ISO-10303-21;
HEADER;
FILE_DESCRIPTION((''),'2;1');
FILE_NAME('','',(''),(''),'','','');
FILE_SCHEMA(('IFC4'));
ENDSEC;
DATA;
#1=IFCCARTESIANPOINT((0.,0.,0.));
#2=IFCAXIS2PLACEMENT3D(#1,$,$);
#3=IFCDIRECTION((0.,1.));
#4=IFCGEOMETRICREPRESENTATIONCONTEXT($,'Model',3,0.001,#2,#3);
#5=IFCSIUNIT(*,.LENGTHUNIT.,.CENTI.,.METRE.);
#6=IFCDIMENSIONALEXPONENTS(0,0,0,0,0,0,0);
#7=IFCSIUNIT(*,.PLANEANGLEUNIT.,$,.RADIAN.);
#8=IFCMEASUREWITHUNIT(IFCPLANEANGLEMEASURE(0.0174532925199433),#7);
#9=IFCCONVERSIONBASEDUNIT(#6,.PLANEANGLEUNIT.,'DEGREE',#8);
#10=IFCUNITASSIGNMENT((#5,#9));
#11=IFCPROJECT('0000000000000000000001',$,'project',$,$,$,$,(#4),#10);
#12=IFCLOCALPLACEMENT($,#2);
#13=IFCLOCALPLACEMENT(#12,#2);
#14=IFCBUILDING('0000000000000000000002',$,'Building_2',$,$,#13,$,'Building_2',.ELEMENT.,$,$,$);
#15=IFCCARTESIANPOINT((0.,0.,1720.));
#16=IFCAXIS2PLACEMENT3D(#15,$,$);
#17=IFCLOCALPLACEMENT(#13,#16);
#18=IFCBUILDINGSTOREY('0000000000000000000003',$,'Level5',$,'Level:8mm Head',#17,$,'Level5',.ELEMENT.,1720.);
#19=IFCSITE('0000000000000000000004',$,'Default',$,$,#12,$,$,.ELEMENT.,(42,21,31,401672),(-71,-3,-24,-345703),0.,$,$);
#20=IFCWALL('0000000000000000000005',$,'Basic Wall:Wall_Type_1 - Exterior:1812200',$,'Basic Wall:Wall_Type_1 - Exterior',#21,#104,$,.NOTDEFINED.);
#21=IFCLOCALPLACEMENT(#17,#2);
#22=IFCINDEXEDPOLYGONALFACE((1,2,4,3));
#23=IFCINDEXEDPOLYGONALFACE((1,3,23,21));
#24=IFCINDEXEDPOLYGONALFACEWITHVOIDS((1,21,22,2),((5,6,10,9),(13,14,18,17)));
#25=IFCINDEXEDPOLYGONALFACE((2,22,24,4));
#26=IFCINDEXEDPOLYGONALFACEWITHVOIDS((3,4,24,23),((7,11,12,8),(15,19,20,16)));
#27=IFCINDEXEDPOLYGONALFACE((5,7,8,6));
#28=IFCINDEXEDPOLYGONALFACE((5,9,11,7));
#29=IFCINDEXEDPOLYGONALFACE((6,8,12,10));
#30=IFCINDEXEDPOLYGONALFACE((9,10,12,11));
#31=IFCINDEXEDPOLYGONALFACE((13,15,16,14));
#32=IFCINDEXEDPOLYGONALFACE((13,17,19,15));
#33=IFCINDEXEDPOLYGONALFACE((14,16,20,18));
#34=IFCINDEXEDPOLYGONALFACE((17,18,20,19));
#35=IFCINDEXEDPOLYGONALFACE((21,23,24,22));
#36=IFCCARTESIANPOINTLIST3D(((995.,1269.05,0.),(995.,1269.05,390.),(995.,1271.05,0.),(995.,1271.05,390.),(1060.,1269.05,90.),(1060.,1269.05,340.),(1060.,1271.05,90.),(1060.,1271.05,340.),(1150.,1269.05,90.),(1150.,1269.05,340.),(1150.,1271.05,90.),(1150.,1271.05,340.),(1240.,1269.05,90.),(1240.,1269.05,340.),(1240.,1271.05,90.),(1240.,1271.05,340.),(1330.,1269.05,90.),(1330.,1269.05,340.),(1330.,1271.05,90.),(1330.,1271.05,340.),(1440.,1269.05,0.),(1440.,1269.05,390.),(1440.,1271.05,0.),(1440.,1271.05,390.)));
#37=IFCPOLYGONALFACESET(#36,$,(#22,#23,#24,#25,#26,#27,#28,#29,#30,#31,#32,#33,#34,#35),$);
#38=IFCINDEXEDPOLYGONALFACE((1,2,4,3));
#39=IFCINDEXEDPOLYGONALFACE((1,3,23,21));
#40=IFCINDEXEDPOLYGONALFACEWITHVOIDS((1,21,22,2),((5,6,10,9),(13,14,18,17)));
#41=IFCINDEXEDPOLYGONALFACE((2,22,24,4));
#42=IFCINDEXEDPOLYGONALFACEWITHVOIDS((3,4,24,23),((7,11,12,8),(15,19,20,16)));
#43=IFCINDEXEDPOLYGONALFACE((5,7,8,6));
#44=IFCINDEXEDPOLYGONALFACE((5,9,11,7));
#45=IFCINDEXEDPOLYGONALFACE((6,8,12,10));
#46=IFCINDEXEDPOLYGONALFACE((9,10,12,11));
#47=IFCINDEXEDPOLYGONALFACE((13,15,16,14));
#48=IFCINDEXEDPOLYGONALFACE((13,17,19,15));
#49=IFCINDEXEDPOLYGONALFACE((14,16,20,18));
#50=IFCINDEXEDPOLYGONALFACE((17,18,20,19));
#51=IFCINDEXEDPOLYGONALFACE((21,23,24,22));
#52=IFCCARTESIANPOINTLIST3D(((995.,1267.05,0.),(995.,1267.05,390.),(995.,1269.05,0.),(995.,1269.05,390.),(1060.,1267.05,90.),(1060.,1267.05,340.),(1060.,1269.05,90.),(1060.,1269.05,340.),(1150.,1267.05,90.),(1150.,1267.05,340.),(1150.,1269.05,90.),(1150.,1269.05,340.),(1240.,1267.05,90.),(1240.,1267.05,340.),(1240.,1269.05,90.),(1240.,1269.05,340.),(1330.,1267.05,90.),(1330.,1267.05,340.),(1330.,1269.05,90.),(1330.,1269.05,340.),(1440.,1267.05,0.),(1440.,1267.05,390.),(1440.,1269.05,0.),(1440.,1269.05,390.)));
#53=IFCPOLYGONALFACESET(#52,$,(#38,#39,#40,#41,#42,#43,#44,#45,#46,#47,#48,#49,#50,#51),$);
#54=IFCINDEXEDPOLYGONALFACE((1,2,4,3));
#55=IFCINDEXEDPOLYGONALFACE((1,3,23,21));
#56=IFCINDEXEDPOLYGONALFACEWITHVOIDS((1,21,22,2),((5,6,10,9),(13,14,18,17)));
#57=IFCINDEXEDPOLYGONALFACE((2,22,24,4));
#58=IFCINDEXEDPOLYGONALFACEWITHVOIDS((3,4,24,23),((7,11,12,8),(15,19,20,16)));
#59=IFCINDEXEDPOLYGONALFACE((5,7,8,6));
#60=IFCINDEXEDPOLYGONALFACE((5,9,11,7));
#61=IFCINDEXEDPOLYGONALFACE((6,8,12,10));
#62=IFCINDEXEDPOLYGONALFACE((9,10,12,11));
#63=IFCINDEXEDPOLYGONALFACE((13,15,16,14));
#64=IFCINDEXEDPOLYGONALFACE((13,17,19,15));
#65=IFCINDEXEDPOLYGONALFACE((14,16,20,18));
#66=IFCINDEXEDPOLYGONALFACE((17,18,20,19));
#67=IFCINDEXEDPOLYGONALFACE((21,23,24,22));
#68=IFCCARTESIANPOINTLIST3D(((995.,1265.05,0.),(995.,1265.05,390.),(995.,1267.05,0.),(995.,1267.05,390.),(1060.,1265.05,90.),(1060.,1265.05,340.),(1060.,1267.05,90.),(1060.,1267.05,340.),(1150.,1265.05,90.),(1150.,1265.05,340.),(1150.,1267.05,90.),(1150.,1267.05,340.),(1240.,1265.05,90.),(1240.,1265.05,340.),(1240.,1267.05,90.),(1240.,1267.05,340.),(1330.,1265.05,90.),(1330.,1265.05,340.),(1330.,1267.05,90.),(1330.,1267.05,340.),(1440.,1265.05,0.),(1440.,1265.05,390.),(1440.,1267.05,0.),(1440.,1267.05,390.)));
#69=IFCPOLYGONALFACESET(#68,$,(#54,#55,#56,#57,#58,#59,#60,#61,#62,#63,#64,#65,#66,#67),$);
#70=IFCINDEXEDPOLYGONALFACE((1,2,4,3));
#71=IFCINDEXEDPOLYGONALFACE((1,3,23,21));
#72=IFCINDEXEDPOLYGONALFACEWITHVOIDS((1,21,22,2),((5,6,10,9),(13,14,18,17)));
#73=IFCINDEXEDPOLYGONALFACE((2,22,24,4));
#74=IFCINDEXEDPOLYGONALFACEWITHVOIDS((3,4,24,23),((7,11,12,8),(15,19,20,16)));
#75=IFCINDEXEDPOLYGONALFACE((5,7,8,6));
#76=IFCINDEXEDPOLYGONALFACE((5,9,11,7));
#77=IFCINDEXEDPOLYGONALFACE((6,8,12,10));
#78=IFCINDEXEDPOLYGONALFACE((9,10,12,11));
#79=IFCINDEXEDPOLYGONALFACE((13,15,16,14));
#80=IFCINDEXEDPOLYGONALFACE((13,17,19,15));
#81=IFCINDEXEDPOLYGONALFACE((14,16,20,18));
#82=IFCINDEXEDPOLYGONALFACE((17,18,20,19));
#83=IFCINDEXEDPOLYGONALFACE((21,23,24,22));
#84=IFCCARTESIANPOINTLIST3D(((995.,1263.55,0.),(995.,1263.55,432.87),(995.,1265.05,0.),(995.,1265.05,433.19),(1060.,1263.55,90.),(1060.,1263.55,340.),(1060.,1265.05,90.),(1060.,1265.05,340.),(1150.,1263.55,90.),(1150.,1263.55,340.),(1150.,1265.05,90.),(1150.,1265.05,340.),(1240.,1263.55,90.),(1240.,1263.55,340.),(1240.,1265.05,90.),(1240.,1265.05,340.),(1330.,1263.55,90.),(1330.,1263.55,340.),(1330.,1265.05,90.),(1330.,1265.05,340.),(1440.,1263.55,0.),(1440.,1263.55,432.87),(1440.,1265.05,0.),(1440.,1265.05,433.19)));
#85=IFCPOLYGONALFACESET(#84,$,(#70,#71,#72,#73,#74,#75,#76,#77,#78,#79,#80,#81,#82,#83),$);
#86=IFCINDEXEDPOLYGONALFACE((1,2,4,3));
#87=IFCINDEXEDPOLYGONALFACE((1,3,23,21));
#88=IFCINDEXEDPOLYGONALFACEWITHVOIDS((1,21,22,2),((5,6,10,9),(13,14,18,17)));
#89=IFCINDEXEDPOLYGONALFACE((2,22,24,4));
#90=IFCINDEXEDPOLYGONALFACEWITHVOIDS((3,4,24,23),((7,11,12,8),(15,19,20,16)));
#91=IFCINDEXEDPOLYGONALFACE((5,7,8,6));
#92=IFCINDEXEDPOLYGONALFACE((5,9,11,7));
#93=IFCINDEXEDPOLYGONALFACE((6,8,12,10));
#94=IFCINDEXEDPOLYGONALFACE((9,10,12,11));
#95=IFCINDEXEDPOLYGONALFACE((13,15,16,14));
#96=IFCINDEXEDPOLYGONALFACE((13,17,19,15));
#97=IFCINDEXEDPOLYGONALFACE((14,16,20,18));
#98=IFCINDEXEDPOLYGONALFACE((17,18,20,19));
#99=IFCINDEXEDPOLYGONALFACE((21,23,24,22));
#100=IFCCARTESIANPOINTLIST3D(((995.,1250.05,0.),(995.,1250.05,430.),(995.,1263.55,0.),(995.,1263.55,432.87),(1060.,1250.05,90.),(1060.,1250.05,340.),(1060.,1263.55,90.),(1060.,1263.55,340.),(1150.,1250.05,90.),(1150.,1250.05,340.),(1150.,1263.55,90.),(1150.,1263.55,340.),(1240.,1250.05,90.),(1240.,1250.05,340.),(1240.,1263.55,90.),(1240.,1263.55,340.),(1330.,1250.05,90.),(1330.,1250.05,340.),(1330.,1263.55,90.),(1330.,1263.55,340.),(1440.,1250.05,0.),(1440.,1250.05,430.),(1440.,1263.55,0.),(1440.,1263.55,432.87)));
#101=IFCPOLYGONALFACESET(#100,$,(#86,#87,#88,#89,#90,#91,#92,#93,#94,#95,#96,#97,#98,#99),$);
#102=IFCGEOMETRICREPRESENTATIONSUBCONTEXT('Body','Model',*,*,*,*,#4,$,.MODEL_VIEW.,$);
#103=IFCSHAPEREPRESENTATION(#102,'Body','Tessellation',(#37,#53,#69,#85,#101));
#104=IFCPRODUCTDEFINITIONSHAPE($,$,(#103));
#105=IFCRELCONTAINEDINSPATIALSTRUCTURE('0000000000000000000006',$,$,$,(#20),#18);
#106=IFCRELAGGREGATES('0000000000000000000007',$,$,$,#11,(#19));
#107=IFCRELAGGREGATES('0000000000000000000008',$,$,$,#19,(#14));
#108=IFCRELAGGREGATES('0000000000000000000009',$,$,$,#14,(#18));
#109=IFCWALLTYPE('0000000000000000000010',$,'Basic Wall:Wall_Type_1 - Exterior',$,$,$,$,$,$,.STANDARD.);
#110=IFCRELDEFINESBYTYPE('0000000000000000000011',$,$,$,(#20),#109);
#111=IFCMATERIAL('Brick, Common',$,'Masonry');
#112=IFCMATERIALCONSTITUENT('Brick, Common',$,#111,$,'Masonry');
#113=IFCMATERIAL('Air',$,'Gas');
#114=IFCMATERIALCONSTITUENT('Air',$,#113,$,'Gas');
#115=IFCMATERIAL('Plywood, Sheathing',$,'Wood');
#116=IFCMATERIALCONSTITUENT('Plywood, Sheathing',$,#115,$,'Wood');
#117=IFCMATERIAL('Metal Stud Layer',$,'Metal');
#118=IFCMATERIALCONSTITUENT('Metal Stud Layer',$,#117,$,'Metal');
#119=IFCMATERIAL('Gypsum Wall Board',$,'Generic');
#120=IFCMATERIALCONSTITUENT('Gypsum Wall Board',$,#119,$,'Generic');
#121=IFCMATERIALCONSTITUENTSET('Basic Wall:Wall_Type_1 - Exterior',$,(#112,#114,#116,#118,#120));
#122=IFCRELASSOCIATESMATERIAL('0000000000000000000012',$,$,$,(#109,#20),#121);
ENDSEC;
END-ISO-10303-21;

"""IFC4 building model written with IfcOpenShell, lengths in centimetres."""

from ifc_helpers import new_model, entity, si_unit, converted_unit, direction, frame, origin, place, context, subcontext, project, spatial, indexed_curve, outline, extrude, material, constituent, constituent_set, type_object, element, save


model = new_model("IFC4")

# Units and contexts
model_context = context("Model", 3, precision=0.001, world=origin(), true_north=direction((0.0, 1.0)))
body_context = subcontext(model_context, "Body", "Model", "MODEL_VIEW")
ifc_project = project(units=[si_unit("LENGTHUNIT", "METRE", prefix="CENTI"), converted_unit("PLANEANGLEUNIT", "DEGREE", entity("IfcPlaneAngleMeasure", 0.0174532925199433), si_unit("PLANEANGLEUNIT", "RADIAN"), dimensions=[0, 0, 0, 0, 0, 0, 0])], contexts=[model_context])

# Site, building, storey
site_placement = place(None, origin())
site = spatial("IfcSite", under=ifc_project, at=site_placement, Name="Default", CompositionType="ELEMENT", RefLatitude=(42, 21, 31, 401672), RefLongitude=(-71, -3, -24, -345703), RefElevation=0.0)
building_placement = place(site_placement, origin())
building = spatial("IfcBuilding", under=site, at=building_placement, Name="Building_2", LongName="Building_2", CompositionType="ELEMENT")
storey_placement = place(building_placement, frame((0.0, 0.0, 1720.0)))
storey = spatial("IfcBuildingStorey", under=building, at=storey_placement, Name="Level5", ObjectType="Level:8mm Head", LongName="Level5", CompositionType="ELEMENT", Elevation=1720.0)

# Shared definitions
ifc_material_1 = material(Name="Brick, Common", Category="Masonry")
ifc_constituent_1 = constituent(ifc_material_1, Name="Brick, Common", Category="Masonry")
ifc_material_2 = material(Name="Air", Category="Gas")
ifc_constituent_2 = constituent(ifc_material_2, Name="Air", Category="Gas")
ifc_material_3 = material(Name="Plywood, Sheathing", Category="Wood")
ifc_constituent_3 = constituent(ifc_material_3, Name="Plywood, Sheathing", Category="Wood")
ifc_material_4 = material(Name="Metal Stud Layer", Category="Metal")
ifc_constituent_4 = constituent(ifc_material_4, Name="Metal Stud Layer", Category="Metal")
ifc_material_5 = material(Name="Gypsum Wall Board", Category="Generic")
ifc_constituent_5 = constituent(ifc_material_5, Name="Gypsum Wall Board", Category="Generic")
ifc_constituent_set_1 = constituent_set(constituents=[ifc_constituent_1, ifc_constituent_2, ifc_constituent_3, ifc_constituent_4, ifc_constituent_5], Name="Basic Wall:Wall_Type_1 - Exterior")
wall_type_1 = type_object("IfcWallType", Name="Basic Wall:Wall_Type_1 - Exterior", PredefinedType="STANDARD", material=ifc_constituent_set_1)

# Wall, openings
wall_1_placement = place(storey_placement, frame((1440.0, 1260.55, 0.0), z_axis=(0.0, 0.0, 1.0), x_axis=(-1.0, 0.0, 0.0)))
wall_1 = element("IfcWall", 1, at=wall_1_placement, inside=storey, type_object=wall_type_1, material=ifc_constituent_set_1, Name="Basic Wall:Wall_Type_1 - Exterior:1812200", ObjectType="Basic Wall:Wall_Type_1 - Exterior", PredefinedType="NOTDEFINED", context=body_context, shape_type="SweptSolid", body=[
    extrude(outline(indexed_curve([(-195.0, -222.5), (195.0, -222.5), (195.0, 222.5), (-195.0, 222.5), (-195.0, -222.5)], self_intersect=False), holes=[indexed_curve([(145.0, -157.5), (-105.0, -157.5), (-105.0, -67.5), (145.0, -67.5), (145.0, -157.5)], self_intersect=False), indexed_curve([(145.0, 22.5), (-105.0, 22.5), (-105.0, 112.5), (145.0, 112.5), (145.0, 22.5)], self_intersect=False)]), frame((222.5, -8.5, 195.0), z_axis=(0.0, -1.0, 0.0), x_axis=(0.0, 0.0, 1.0)), (0.0, 0.0, 1.0), 2.0),
    extrude(outline(indexed_curve([(-195.0, -222.5), (195.0, -222.5), (195.0, 222.5), (-195.0, 222.5), (-195.0, -222.5)], self_intersect=False), holes=[indexed_curve([(145.0, -157.5), (-105.0, -157.5), (-105.0, -67.5), (145.0, -67.5), (145.0, -157.5)], self_intersect=False), indexed_curve([(145.0, 22.5), (-105.0, 22.5), (-105.0, 112.5), (145.0, 112.5), (145.0, 22.5)], self_intersect=False)]), frame((222.5, -6.5, 195.0), z_axis=(0.0, -1.0, 0.0), x_axis=(0.0, 0.0, 1.0)), (0.0, 0.0, 1.0), 2.0),
    extrude(outline(indexed_curve([(-195.0, -222.5), (195.0, -222.5), (195.0, 222.5), (-195.0, 222.5), (-195.0, -222.5)], self_intersect=False), holes=[indexed_curve([(145.0, -157.5), (-105.0, -157.5), (-105.0, -67.5), (145.0, -67.5), (145.0, -157.5)], self_intersect=False), indexed_curve([(145.0, 22.5), (-105.0, 22.5), (-105.0, 112.5), (145.0, 112.5), (145.0, 22.5)], self_intersect=False)]), frame((222.5, -4.5, 195.0), z_axis=(0.0, -1.0, 0.0), x_axis=(0.0, 0.0, 1.0)), (0.0, 0.0, 1.0), 2.0),
    extrude(outline(indexed_curve([(-181.66, -0.9), (251.21, -0.9), (251.21, 0.6), (-138.79, 0.6), (-181.98, 0.6), (-181.66, -0.9)], self_intersect=False)), frame((445.0, -3.9, 251.21), z_axis=(-1.0, 0.0, 0.0), x_axis=(0.0, 0.0, -1.0)), (0.0, 0.0, 1.0), 445.0),
    extrude(outline(indexed_curve([(-6.75, -215.72), (6.75, -215.72), (6.75, 217.15), (-6.75, 214.28), (-6.75, -215.72)], self_intersect=False)), frame((445.0, 3.75, 215.72), z_axis=(-1.0, 0.0, 0.0), x_axis=(0.0, -1.0, 0.0)), (0.0, 0.0, 1.0), 445.0),
])
opening_1_placement = place(storey_placement, frame((1440.0, 1260.55, 0.0), z_axis=(0.0, 0.0, 1.0), x_axis=(-1.0, 0.0, 0.0)))
element("IfcOpeningElement", 2, at=opening_1_placement, cuts=wall_1, PredefinedType="OPENING", context=body_context, shape_type="SweptSolid", body=[
    extrude(outline(indexed_curve([(-45.0, -125.0), (45.0, -125.0), (45.0, 125.0), (-45.0, 125.0), (-45.0, -125.0)], self_intersect=False)), frame((335.0, 10.5, 215.0), z_axis=(0.0, -1.0, 0.0), x_axis=(-1.0, 0.0, 0.0)), (0.0, 0.0, 1.0), 13.5),
])
opening_2_placement = place(storey_placement, frame((1440.0, 1260.55, 0.0), z_axis=(0.0, 0.0, 1.0), x_axis=(-1.0, 0.0, 0.0)))
element("IfcOpeningElement", 3, at=opening_2_placement, cuts=wall_1, PredefinedType="OPENING", context=body_context, shape_type="SweptSolid", body=[
    extrude(outline(indexed_curve([(-45.0, -125.0), (45.0, -125.0), (45.0, 125.0), (-45.0, 125.0), (-45.0, -125.0)], self_intersect=False)), frame((155.0, 10.5, 215.0), z_axis=(0.0, -1.0, 0.0), x_axis=(-1.0, 0.0, 0.0)), (0.0, 0.0, 1.0), 13.5),
])
opening_3_placement = place(storey_placement, frame((1440.0, 1260.55, 0.0), z_axis=(0.0, 0.0, 1.0), x_axis=(-1.0, 0.0, 0.0)))
element("IfcOpeningElement", 4, at=opening_3_placement, cuts=wall_1, PredefinedType="OPENING", context=body_context, shape_type="SweptSolid", body=[
    extrude(outline(indexed_curve([(-45.0, -125.0), (45.0, -125.0), (45.0, 125.0), (-45.0, 125.0), (-45.0, -125.0)], self_intersect=False)), frame((335.0, -4.5, 215.0), z_axis=(0.0, 1.0, 0.0), x_axis=(1.0, 0.0, 0.0)), (0.0, 0.0, 1.0), 1.5),
])
opening_4_placement = place(storey_placement, frame((1440.0, 1260.55, 0.0), z_axis=(0.0, 0.0, 1.0), x_axis=(-1.0, 0.0, 0.0)))
element("IfcOpeningElement", 5, at=opening_4_placement, cuts=wall_1, PredefinedType="OPENING", context=body_context, shape_type="SweptSolid", body=[
    extrude(outline(indexed_curve([(-45.0, -125.0), (45.0, -125.0), (45.0, 125.0), (-45.0, 125.0), (-45.0, -125.0)], self_intersect=False)), frame((155.0, -4.5, 215.0), z_axis=(0.0, 1.0, 0.0), x_axis=(1.0, 0.0, 0.0)), (0.0, 0.0, 1.0), 1.5),
])
opening_5_placement = place(wall_1_placement, frame((380.0, 10.5, 90.0)))
element("IfcOpeningElement", 6, at=opening_5_placement, cuts=wall_1, PredefinedType="OPENING", context=body_context, shape_type="SweptSolid", body=[
    extrude(outline(indexed_curve([(250.0, 90.0), (0.0, 90.0), (0.0, 0.0), (250.0, 0.0), (250.0, 90.0)], self_intersect=False)), frame((0.0, 0.0, 0.0), z_axis=(0.0, -1.0, 0.0), x_axis=(0.0, 0.0, 1.0)), (0.0, 0.0, 1.0), 21.0),
])
opening_6_placement = place(wall_1_placement, frame((1440.0, 1260.55, 0.0), z_axis=(0.0, 0.0, 1.0), x_axis=(-1.0, 0.0, 0.0)))
element("IfcOpeningElement", 7, at=opening_6_placement, cuts=wall_1, PredefinedType="OPENING", context=body_context, shape_type="SweptSolid", body=[
    extrude(outline(indexed_curve([(-45.0, -125.0), (45.0, -125.0), (45.0, 125.0), (-45.0, 125.0), (-45.0, -125.0)], self_intersect=False)), frame((1105.0, 1402.45, 215.0), z_axis=(0.0, -1.0, 0.0), x_axis=(-1.0, 0.0, 0.0)), (0.0, 0.0, 1.0), 304.8),
])
opening_7_placement = place(wall_1_placement, frame((200.0, 10.5, 90.0)))
element("IfcOpeningElement", 8, at=opening_7_placement, cuts=wall_1, PredefinedType="OPENING", context=body_context, shape_type="SweptSolid", body=[
    extrude(outline(indexed_curve([(250.0, 90.0), (0.0, 90.0), (0.0, 0.0), (250.0, 0.0), (250.0, 90.0)], self_intersect=False)), frame((0.0, 0.0, 0.0), z_axis=(0.0, -1.0, 0.0), x_axis=(0.0, 0.0, 1.0)), (0.0, 0.0, 1.0), 21.0),
])
opening_8_placement = place(wall_1_placement, frame((1440.0, 1260.55, 0.0), z_axis=(0.0, 0.0, 1.0), x_axis=(-1.0, 0.0, 0.0)))
element("IfcOpeningElement", 9, at=opening_8_placement, cuts=wall_1, PredefinedType="OPENING", context=body_context, shape_type="SweptSolid", body=[
    extrude(outline(indexed_curve([(-45.0, -125.0), (45.0, -125.0), (45.0, 125.0), (-45.0, 125.0), (-45.0, -125.0)], self_intersect=False)), frame((1285.0, 1402.45, 215.0), z_axis=(0.0, -1.0, 0.0), x_axis=(-1.0, 0.0, 0.0)), (0.0, 0.0, 1.0), 304.8),
])

save(model, "model.ifc")
